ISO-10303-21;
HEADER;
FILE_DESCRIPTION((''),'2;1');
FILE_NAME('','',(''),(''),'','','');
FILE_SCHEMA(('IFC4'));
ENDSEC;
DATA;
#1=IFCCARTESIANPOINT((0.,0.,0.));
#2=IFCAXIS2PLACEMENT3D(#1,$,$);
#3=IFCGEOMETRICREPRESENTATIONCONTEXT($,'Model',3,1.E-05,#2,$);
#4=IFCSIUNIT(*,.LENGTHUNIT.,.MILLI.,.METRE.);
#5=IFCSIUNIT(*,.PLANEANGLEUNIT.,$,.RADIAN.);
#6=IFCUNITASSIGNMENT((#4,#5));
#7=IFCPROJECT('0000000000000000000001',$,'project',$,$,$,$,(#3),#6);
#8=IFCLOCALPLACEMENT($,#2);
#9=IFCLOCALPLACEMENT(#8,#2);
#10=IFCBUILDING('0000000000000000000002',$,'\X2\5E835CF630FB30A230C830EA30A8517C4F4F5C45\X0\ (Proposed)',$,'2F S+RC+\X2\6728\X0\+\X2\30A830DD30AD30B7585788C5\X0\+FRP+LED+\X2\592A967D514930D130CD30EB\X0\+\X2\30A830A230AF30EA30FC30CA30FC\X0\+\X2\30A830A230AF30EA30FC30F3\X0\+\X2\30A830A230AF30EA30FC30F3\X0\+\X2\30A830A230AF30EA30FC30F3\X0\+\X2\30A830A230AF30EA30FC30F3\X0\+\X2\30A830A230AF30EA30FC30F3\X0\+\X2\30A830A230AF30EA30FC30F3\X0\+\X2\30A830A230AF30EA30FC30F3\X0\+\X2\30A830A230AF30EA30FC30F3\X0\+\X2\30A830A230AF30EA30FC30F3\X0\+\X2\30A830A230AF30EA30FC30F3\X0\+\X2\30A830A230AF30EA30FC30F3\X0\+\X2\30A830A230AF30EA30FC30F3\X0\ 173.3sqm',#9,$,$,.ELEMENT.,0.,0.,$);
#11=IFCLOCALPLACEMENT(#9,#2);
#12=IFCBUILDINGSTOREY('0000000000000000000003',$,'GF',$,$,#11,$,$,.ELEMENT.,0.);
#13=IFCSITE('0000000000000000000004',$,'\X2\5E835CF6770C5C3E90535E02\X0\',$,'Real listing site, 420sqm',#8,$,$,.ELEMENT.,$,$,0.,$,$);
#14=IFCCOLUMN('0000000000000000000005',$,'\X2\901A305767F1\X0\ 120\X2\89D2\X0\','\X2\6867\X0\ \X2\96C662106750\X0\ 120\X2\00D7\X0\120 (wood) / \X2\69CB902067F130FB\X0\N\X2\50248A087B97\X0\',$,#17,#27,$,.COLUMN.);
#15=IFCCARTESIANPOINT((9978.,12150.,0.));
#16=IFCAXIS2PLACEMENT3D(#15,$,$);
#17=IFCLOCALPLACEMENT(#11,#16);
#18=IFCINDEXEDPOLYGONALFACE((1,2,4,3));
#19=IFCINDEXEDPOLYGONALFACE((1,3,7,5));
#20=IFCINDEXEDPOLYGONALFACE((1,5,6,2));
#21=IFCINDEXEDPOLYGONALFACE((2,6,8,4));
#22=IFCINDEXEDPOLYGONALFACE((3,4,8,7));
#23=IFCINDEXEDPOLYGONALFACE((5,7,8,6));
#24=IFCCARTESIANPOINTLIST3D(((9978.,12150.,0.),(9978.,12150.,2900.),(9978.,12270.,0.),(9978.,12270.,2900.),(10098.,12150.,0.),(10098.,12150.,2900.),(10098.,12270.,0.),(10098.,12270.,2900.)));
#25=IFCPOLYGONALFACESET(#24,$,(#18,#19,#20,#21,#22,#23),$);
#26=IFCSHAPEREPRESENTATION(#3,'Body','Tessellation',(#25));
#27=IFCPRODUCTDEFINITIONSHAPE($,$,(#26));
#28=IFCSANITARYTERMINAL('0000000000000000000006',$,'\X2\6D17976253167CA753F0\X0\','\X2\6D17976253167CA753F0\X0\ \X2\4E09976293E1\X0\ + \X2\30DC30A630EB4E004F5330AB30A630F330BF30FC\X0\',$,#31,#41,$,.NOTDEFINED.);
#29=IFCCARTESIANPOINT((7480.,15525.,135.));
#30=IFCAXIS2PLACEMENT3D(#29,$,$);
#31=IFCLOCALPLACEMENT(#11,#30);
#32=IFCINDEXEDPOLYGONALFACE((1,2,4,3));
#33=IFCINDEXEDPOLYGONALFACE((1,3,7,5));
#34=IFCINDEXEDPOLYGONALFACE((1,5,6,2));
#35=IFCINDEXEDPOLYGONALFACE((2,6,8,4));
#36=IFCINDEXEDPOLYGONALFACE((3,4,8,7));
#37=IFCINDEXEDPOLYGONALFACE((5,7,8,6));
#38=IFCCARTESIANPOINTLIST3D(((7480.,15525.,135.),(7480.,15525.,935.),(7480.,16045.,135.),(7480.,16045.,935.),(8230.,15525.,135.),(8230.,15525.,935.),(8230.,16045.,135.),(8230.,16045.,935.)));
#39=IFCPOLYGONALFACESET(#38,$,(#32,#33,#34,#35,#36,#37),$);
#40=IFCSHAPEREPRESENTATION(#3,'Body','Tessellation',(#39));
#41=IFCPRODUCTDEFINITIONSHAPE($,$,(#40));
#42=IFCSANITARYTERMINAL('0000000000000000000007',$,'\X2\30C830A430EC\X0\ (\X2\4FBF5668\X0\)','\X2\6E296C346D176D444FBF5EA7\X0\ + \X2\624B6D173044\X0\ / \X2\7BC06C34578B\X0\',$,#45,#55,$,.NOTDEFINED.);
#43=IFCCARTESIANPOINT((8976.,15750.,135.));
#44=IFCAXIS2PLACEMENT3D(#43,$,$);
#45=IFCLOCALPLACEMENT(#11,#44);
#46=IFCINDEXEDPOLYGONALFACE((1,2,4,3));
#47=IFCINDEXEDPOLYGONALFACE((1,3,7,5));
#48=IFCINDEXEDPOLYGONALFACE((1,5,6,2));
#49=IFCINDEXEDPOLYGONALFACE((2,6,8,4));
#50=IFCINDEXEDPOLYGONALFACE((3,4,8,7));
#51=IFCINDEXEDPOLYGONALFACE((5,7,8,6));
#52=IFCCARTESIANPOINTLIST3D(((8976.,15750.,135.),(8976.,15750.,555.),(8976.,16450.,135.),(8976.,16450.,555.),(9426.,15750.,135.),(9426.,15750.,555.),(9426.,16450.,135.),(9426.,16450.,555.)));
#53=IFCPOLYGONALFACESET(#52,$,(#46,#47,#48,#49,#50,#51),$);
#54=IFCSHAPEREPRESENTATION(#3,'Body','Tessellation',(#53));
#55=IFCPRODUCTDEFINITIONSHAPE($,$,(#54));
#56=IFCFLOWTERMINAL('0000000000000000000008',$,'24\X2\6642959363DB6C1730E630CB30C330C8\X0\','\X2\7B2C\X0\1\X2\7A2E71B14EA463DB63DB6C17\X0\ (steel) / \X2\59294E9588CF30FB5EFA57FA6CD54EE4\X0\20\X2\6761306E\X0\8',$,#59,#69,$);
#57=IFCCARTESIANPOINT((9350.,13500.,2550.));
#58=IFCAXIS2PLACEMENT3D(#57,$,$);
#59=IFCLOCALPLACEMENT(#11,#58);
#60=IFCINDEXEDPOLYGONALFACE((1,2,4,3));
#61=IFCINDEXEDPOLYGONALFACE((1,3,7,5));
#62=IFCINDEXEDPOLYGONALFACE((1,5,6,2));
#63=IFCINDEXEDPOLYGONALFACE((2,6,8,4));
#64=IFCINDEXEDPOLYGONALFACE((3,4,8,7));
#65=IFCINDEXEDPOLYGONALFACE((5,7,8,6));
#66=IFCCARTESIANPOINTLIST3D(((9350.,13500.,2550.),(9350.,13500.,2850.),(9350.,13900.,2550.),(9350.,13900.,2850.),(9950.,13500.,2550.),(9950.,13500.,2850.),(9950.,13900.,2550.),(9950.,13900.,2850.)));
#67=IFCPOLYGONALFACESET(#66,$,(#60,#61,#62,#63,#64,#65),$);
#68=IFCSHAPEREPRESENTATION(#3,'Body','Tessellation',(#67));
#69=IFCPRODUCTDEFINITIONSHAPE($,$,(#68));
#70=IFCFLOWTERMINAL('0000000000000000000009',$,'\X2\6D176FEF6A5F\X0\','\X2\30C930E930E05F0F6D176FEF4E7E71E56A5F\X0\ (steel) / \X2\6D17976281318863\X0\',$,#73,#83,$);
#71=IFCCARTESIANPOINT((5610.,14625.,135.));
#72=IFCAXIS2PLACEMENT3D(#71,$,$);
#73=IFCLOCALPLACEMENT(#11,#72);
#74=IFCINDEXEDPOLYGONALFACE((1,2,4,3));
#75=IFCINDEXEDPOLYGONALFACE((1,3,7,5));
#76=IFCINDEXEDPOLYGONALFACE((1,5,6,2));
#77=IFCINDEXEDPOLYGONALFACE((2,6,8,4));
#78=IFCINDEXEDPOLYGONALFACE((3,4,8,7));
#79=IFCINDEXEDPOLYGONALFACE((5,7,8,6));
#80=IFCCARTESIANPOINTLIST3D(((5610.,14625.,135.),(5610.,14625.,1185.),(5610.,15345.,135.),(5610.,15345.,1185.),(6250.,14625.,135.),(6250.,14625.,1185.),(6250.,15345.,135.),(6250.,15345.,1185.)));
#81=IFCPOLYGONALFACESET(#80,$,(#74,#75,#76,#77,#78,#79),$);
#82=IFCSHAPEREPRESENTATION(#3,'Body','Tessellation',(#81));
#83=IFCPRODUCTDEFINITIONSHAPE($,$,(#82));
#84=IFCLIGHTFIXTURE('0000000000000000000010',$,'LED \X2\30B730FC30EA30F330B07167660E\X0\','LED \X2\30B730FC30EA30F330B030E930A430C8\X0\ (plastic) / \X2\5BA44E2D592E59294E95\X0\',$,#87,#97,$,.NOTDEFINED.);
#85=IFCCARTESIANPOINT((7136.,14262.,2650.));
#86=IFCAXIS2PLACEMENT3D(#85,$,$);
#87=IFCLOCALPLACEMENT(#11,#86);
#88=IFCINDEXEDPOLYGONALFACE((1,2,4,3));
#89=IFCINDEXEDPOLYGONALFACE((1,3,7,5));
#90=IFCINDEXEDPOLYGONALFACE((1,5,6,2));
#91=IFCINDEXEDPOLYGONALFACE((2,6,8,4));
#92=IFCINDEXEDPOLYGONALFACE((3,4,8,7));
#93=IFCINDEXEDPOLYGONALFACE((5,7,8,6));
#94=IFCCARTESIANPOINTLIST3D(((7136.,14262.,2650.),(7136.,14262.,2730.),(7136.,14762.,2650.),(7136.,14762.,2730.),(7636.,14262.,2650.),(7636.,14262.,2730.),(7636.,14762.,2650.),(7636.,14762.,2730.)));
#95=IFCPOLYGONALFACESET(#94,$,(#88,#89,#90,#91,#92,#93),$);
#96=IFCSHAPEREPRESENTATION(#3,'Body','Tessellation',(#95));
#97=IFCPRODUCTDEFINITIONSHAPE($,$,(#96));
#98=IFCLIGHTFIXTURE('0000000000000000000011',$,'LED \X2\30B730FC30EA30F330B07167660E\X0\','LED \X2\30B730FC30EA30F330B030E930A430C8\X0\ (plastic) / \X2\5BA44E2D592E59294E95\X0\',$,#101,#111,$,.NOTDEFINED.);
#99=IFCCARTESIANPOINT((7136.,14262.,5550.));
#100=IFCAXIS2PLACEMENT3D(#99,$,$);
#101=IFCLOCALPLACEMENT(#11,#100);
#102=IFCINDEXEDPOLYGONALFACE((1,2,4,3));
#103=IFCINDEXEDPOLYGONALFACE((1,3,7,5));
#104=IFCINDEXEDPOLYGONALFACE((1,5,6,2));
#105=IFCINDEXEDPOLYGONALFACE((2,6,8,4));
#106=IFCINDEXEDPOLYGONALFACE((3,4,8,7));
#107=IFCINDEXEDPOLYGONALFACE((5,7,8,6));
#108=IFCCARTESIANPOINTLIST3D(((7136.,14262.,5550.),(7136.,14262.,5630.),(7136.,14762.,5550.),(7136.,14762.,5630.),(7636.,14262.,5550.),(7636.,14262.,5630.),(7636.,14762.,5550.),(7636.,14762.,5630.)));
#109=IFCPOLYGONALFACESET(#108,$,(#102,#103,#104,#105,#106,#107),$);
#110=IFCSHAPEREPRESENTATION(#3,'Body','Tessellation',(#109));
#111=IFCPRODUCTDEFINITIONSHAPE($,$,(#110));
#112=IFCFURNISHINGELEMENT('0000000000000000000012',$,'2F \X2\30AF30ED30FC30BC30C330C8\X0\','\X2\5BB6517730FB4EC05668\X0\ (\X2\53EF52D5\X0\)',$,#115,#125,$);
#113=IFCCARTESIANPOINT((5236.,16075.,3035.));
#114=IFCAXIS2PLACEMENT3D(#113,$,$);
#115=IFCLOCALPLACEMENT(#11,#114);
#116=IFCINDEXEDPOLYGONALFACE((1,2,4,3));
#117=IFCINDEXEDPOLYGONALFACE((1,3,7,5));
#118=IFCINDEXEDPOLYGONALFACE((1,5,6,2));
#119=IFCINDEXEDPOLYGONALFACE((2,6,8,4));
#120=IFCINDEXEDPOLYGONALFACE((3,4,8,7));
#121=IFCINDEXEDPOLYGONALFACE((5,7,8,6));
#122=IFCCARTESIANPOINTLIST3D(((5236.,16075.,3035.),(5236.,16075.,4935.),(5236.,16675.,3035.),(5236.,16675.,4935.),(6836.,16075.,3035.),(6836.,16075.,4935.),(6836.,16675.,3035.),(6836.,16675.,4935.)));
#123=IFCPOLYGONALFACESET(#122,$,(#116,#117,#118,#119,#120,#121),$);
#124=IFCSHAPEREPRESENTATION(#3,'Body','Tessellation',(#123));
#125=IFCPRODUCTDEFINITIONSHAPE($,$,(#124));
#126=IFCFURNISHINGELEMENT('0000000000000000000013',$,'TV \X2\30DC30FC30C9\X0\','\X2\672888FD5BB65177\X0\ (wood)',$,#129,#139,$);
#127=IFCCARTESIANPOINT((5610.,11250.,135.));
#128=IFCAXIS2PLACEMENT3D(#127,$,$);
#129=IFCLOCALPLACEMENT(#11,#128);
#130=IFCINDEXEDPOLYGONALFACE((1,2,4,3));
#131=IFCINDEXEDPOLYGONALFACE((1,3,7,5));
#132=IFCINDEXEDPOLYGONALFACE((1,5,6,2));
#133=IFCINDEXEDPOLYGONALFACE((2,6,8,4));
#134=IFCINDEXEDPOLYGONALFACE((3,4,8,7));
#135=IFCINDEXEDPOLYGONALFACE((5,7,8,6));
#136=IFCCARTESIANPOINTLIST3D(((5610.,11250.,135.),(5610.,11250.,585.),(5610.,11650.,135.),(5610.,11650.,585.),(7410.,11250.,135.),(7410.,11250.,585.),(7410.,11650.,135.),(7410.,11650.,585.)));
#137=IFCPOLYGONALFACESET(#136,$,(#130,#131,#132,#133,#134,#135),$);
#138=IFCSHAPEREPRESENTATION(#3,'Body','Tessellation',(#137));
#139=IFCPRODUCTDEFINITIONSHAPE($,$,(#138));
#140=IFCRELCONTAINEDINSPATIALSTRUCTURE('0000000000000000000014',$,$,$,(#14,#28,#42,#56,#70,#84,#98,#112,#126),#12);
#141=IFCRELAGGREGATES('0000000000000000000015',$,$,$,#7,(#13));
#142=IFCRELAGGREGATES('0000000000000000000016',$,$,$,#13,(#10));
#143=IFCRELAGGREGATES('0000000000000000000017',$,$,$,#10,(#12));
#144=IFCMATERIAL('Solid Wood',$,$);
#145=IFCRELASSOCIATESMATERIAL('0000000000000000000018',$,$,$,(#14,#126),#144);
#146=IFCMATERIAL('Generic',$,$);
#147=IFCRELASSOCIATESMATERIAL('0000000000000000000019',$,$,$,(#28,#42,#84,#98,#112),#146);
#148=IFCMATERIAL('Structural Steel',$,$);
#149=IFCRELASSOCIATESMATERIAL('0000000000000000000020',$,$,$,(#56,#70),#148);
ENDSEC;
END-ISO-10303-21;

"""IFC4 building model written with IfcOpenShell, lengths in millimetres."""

from ifc_helpers import new_model, si_unit, frame, frame_2d, origin, place, context, project, spatial, rectangle, extrude, material, element, save


model = new_model("IFC4")

# Units and contexts
model_context = context("Model", 3, precision=1e-05, world=origin())
ifc_project = project(units=[si_unit("LENGTHUNIT", "METRE", prefix="MILLI"), si_unit("PLANEANGLEUNIT", "RADIAN")], contexts=[model_context])

# Site, building, storey
site_placement = place(None, origin())
site = spatial("IfcSite", under=ifc_project, at=site_placement, Name="広島県尾道市", ObjectType="Real listing site, 420sqm", CompositionType="ELEMENT", RefElevation=0.0)
building_placement = place(site_placement, origin())
building = spatial("IfcBuilding", under=site, at=building_placement, Name="広島・アトリエ兼住居 (Proposed)", ObjectType="2F S+RC+木+エポキシ塗装+FRP+LED+太陽光パネル+エアクリーナー+エアクリーン+エアクリーン+エアクリーン+エアクリーン+エアクリーン+エアクリーン+エアクリーン+エアクリーン+エアクリーン+エアクリーン+エアクリーン+エアクリーン 173.3sqm", CompositionType="ELEMENT", ElevationOfRefHeight=0.0, ElevationOfTerrain=0.0)
storey_placement = place(building_placement, origin())
storey = spatial("IfcBuildingStorey", under=building, at=storey_placement, Name="GF", CompositionType="ELEMENT", Elevation=0.0)

# Column
ifc_material_1 = material(Name="Solid Wood")
column_1_placement = place(storey_placement, frame((9978.0, 12150.0, 0.0)))
element("IfcColumn", 1, at=column_1_placement, inside=storey, material=ifc_material_1, Name="通し柱 120角", Description="桧 集成材 120×120 (wood) / 構造柱・N値計算", PredefinedType="COLUMN", context=model_context, shape_type="SweptSolid", body=[
    extrude(rectangle(XDim=120.0, YDim=120.0, at=frame_2d((60.0, 60.0))), frame((9978.0, 12150.0, 0.0)), (0.0, 0.0, 1.0), 2900.0),
])

# Sanitary terminals
ifc_material_2 = material(Name="Generic")
sanitary_terminal_1_placement = place(storey_placement, frame((7480.0, 15525.0, 135.0)))
element("IfcSanitaryTerminal", 2, at=sanitary_terminal_1_placement, inside=storey, material=ifc_material_2, Name="洗面化粧台", Description="洗面化粧台 三面鏡 + ボウル一体カウンター", PredefinedType="NOTDEFINED", context=model_context, shape_type="SweptSolid", body=[
    extrude(rectangle(XDim=750.0, YDim=520.0, at=frame_2d((375.0, 260.0))), frame((7480.0, 15525.0, 135.0)), (0.0, 0.0, 1.0), 800.0),
])
sanitary_terminal_2_placement = place(storey_placement, frame((8976.0, 15750.0, 135.0)))
element("IfcSanitaryTerminal", 3, at=sanitary_terminal_2_placement, inside=storey, material=ifc_material_2, Name="トイレ (便器)", Description="温水洗浄便座 + 手洗い / 節水型", PredefinedType="NOTDEFINED", context=model_context, shape_type="SweptSolid", body=[
    extrude(rectangle(XDim=450.0, YDim=700.0, at=frame_2d((225.0, 350.0))), frame((8976.0, 15750.0, 135.0)), (0.0, 0.0, 1.0), 420.0),
])

# Flow terminals
ifc_material_3 = material(Name="Structural Steel")
flow_terminal_1_placement = place(storey_placement, frame((9350.0, 13500.0, 2550.0)))
element("IfcFlowTerminal", 4, at=flow_terminal_1_placement, inside=storey, material=ifc_material_3, Name="24時間換気ユニット", Description="第1種熱交換換気 (steel) / 天井裏・建基法令20条の8", context=model_context, shape_type="SweptSolid", body=[
    extrude(rectangle(XDim=600.0, YDim=400.0, at=frame_2d((300.0, 200.0))), frame((9350.0, 13500.0, 2550.0)), (0.0, 0.0, 1.0), 300.0),
])
flow_terminal_2_placement = place(storey_placement, frame((5610.0, 14625.0, 135.0)))
element("IfcFlowTerminal", 5, at=flow_terminal_2_placement, inside=storey, material=ifc_material_3, Name="洗濯機", Description="ドラム式洗濯乾燥機 (steel) / 洗面脱衣", context=model_context, shape_type="SweptSolid", body=[
    extrude(rectangle(XDim=640.0, YDim=720.0, at=frame_2d((320.0, 360.0))), frame((5610.0, 14625.0, 135.0)), (0.0, 0.0, 1.0), 1050.0),
])

# Light fixtures
light_fixture_1_placement = place(storey_placement, frame((7136.0, 14262.0, 2650.0)))
element("IfcLightFixture", 6, at=light_fixture_1_placement, inside=storey, material=ifc_material_2, Name="LED シーリング照明", Description="LED シーリングライト (plastic) / 室中央天井", PredefinedType="NOTDEFINED", context=model_context, shape_type="SweptSolid", body=[
    extrude(rectangle(XDim=500.0, YDim=500.0, at=frame_2d((250.0, 250.0))), frame((7136.0, 14262.0, 2650.0)), (0.0, 0.0, 1.0), 80.0),
])
light_fixture_2_placement = place(storey_placement, frame((7136.0, 14262.0, 5550.0)))
element("IfcLightFixture", 7, at=light_fixture_2_placement, inside=storey, material=ifc_material_2, Name="LED シーリング照明", Description="LED シーリングライト (plastic) / 室中央天井", PredefinedType="NOTDEFINED", context=model_context, shape_type="SweptSolid", body=[
    extrude(rectangle(XDim=500.0, YDim=500.0, at=frame_2d((250.0, 250.0))), frame((7136.0, 14262.0, 5550.0)), (0.0, 0.0, 1.0), 80.0),
])

# Furnishing elements
furnishing_1_placement = place(storey_placement, frame((5236.0, 16075.0, 3035.0)))
element("IfcFurnishingElement", 8, at=furnishing_1_placement, inside=storey, material=ifc_material_2, Name="2F クローゼット", Description="家具・什器 (可動)", context=model_context, shape_type="SweptSolid", body=[
    extrude(rectangle(XDim=1600.0, YDim=600.0, at=frame_2d((800.0, 300.0))), frame((5236.0, 16075.0, 3035.0)), (0.0, 0.0, 1.0), 1900.0),
])
furnishing_2_placement = place(storey_placement, frame((5610.0, 11250.0, 135.0)))
element("IfcFurnishingElement", 9, at=furnishing_2_placement, inside=storey, material=ifc_material_1, Name="TV ボード", Description="木製家具 (wood)", context=model_context, shape_type="SweptSolid", body=[
    extrude(rectangle(XDim=1800.0, YDim=400.0, at=frame_2d((900.0, 200.0))), frame((5610.0, 11250.0, 135.0)), (0.0, 0.0, 1.0), 450.0),
])

save(model, "model.ifc")
